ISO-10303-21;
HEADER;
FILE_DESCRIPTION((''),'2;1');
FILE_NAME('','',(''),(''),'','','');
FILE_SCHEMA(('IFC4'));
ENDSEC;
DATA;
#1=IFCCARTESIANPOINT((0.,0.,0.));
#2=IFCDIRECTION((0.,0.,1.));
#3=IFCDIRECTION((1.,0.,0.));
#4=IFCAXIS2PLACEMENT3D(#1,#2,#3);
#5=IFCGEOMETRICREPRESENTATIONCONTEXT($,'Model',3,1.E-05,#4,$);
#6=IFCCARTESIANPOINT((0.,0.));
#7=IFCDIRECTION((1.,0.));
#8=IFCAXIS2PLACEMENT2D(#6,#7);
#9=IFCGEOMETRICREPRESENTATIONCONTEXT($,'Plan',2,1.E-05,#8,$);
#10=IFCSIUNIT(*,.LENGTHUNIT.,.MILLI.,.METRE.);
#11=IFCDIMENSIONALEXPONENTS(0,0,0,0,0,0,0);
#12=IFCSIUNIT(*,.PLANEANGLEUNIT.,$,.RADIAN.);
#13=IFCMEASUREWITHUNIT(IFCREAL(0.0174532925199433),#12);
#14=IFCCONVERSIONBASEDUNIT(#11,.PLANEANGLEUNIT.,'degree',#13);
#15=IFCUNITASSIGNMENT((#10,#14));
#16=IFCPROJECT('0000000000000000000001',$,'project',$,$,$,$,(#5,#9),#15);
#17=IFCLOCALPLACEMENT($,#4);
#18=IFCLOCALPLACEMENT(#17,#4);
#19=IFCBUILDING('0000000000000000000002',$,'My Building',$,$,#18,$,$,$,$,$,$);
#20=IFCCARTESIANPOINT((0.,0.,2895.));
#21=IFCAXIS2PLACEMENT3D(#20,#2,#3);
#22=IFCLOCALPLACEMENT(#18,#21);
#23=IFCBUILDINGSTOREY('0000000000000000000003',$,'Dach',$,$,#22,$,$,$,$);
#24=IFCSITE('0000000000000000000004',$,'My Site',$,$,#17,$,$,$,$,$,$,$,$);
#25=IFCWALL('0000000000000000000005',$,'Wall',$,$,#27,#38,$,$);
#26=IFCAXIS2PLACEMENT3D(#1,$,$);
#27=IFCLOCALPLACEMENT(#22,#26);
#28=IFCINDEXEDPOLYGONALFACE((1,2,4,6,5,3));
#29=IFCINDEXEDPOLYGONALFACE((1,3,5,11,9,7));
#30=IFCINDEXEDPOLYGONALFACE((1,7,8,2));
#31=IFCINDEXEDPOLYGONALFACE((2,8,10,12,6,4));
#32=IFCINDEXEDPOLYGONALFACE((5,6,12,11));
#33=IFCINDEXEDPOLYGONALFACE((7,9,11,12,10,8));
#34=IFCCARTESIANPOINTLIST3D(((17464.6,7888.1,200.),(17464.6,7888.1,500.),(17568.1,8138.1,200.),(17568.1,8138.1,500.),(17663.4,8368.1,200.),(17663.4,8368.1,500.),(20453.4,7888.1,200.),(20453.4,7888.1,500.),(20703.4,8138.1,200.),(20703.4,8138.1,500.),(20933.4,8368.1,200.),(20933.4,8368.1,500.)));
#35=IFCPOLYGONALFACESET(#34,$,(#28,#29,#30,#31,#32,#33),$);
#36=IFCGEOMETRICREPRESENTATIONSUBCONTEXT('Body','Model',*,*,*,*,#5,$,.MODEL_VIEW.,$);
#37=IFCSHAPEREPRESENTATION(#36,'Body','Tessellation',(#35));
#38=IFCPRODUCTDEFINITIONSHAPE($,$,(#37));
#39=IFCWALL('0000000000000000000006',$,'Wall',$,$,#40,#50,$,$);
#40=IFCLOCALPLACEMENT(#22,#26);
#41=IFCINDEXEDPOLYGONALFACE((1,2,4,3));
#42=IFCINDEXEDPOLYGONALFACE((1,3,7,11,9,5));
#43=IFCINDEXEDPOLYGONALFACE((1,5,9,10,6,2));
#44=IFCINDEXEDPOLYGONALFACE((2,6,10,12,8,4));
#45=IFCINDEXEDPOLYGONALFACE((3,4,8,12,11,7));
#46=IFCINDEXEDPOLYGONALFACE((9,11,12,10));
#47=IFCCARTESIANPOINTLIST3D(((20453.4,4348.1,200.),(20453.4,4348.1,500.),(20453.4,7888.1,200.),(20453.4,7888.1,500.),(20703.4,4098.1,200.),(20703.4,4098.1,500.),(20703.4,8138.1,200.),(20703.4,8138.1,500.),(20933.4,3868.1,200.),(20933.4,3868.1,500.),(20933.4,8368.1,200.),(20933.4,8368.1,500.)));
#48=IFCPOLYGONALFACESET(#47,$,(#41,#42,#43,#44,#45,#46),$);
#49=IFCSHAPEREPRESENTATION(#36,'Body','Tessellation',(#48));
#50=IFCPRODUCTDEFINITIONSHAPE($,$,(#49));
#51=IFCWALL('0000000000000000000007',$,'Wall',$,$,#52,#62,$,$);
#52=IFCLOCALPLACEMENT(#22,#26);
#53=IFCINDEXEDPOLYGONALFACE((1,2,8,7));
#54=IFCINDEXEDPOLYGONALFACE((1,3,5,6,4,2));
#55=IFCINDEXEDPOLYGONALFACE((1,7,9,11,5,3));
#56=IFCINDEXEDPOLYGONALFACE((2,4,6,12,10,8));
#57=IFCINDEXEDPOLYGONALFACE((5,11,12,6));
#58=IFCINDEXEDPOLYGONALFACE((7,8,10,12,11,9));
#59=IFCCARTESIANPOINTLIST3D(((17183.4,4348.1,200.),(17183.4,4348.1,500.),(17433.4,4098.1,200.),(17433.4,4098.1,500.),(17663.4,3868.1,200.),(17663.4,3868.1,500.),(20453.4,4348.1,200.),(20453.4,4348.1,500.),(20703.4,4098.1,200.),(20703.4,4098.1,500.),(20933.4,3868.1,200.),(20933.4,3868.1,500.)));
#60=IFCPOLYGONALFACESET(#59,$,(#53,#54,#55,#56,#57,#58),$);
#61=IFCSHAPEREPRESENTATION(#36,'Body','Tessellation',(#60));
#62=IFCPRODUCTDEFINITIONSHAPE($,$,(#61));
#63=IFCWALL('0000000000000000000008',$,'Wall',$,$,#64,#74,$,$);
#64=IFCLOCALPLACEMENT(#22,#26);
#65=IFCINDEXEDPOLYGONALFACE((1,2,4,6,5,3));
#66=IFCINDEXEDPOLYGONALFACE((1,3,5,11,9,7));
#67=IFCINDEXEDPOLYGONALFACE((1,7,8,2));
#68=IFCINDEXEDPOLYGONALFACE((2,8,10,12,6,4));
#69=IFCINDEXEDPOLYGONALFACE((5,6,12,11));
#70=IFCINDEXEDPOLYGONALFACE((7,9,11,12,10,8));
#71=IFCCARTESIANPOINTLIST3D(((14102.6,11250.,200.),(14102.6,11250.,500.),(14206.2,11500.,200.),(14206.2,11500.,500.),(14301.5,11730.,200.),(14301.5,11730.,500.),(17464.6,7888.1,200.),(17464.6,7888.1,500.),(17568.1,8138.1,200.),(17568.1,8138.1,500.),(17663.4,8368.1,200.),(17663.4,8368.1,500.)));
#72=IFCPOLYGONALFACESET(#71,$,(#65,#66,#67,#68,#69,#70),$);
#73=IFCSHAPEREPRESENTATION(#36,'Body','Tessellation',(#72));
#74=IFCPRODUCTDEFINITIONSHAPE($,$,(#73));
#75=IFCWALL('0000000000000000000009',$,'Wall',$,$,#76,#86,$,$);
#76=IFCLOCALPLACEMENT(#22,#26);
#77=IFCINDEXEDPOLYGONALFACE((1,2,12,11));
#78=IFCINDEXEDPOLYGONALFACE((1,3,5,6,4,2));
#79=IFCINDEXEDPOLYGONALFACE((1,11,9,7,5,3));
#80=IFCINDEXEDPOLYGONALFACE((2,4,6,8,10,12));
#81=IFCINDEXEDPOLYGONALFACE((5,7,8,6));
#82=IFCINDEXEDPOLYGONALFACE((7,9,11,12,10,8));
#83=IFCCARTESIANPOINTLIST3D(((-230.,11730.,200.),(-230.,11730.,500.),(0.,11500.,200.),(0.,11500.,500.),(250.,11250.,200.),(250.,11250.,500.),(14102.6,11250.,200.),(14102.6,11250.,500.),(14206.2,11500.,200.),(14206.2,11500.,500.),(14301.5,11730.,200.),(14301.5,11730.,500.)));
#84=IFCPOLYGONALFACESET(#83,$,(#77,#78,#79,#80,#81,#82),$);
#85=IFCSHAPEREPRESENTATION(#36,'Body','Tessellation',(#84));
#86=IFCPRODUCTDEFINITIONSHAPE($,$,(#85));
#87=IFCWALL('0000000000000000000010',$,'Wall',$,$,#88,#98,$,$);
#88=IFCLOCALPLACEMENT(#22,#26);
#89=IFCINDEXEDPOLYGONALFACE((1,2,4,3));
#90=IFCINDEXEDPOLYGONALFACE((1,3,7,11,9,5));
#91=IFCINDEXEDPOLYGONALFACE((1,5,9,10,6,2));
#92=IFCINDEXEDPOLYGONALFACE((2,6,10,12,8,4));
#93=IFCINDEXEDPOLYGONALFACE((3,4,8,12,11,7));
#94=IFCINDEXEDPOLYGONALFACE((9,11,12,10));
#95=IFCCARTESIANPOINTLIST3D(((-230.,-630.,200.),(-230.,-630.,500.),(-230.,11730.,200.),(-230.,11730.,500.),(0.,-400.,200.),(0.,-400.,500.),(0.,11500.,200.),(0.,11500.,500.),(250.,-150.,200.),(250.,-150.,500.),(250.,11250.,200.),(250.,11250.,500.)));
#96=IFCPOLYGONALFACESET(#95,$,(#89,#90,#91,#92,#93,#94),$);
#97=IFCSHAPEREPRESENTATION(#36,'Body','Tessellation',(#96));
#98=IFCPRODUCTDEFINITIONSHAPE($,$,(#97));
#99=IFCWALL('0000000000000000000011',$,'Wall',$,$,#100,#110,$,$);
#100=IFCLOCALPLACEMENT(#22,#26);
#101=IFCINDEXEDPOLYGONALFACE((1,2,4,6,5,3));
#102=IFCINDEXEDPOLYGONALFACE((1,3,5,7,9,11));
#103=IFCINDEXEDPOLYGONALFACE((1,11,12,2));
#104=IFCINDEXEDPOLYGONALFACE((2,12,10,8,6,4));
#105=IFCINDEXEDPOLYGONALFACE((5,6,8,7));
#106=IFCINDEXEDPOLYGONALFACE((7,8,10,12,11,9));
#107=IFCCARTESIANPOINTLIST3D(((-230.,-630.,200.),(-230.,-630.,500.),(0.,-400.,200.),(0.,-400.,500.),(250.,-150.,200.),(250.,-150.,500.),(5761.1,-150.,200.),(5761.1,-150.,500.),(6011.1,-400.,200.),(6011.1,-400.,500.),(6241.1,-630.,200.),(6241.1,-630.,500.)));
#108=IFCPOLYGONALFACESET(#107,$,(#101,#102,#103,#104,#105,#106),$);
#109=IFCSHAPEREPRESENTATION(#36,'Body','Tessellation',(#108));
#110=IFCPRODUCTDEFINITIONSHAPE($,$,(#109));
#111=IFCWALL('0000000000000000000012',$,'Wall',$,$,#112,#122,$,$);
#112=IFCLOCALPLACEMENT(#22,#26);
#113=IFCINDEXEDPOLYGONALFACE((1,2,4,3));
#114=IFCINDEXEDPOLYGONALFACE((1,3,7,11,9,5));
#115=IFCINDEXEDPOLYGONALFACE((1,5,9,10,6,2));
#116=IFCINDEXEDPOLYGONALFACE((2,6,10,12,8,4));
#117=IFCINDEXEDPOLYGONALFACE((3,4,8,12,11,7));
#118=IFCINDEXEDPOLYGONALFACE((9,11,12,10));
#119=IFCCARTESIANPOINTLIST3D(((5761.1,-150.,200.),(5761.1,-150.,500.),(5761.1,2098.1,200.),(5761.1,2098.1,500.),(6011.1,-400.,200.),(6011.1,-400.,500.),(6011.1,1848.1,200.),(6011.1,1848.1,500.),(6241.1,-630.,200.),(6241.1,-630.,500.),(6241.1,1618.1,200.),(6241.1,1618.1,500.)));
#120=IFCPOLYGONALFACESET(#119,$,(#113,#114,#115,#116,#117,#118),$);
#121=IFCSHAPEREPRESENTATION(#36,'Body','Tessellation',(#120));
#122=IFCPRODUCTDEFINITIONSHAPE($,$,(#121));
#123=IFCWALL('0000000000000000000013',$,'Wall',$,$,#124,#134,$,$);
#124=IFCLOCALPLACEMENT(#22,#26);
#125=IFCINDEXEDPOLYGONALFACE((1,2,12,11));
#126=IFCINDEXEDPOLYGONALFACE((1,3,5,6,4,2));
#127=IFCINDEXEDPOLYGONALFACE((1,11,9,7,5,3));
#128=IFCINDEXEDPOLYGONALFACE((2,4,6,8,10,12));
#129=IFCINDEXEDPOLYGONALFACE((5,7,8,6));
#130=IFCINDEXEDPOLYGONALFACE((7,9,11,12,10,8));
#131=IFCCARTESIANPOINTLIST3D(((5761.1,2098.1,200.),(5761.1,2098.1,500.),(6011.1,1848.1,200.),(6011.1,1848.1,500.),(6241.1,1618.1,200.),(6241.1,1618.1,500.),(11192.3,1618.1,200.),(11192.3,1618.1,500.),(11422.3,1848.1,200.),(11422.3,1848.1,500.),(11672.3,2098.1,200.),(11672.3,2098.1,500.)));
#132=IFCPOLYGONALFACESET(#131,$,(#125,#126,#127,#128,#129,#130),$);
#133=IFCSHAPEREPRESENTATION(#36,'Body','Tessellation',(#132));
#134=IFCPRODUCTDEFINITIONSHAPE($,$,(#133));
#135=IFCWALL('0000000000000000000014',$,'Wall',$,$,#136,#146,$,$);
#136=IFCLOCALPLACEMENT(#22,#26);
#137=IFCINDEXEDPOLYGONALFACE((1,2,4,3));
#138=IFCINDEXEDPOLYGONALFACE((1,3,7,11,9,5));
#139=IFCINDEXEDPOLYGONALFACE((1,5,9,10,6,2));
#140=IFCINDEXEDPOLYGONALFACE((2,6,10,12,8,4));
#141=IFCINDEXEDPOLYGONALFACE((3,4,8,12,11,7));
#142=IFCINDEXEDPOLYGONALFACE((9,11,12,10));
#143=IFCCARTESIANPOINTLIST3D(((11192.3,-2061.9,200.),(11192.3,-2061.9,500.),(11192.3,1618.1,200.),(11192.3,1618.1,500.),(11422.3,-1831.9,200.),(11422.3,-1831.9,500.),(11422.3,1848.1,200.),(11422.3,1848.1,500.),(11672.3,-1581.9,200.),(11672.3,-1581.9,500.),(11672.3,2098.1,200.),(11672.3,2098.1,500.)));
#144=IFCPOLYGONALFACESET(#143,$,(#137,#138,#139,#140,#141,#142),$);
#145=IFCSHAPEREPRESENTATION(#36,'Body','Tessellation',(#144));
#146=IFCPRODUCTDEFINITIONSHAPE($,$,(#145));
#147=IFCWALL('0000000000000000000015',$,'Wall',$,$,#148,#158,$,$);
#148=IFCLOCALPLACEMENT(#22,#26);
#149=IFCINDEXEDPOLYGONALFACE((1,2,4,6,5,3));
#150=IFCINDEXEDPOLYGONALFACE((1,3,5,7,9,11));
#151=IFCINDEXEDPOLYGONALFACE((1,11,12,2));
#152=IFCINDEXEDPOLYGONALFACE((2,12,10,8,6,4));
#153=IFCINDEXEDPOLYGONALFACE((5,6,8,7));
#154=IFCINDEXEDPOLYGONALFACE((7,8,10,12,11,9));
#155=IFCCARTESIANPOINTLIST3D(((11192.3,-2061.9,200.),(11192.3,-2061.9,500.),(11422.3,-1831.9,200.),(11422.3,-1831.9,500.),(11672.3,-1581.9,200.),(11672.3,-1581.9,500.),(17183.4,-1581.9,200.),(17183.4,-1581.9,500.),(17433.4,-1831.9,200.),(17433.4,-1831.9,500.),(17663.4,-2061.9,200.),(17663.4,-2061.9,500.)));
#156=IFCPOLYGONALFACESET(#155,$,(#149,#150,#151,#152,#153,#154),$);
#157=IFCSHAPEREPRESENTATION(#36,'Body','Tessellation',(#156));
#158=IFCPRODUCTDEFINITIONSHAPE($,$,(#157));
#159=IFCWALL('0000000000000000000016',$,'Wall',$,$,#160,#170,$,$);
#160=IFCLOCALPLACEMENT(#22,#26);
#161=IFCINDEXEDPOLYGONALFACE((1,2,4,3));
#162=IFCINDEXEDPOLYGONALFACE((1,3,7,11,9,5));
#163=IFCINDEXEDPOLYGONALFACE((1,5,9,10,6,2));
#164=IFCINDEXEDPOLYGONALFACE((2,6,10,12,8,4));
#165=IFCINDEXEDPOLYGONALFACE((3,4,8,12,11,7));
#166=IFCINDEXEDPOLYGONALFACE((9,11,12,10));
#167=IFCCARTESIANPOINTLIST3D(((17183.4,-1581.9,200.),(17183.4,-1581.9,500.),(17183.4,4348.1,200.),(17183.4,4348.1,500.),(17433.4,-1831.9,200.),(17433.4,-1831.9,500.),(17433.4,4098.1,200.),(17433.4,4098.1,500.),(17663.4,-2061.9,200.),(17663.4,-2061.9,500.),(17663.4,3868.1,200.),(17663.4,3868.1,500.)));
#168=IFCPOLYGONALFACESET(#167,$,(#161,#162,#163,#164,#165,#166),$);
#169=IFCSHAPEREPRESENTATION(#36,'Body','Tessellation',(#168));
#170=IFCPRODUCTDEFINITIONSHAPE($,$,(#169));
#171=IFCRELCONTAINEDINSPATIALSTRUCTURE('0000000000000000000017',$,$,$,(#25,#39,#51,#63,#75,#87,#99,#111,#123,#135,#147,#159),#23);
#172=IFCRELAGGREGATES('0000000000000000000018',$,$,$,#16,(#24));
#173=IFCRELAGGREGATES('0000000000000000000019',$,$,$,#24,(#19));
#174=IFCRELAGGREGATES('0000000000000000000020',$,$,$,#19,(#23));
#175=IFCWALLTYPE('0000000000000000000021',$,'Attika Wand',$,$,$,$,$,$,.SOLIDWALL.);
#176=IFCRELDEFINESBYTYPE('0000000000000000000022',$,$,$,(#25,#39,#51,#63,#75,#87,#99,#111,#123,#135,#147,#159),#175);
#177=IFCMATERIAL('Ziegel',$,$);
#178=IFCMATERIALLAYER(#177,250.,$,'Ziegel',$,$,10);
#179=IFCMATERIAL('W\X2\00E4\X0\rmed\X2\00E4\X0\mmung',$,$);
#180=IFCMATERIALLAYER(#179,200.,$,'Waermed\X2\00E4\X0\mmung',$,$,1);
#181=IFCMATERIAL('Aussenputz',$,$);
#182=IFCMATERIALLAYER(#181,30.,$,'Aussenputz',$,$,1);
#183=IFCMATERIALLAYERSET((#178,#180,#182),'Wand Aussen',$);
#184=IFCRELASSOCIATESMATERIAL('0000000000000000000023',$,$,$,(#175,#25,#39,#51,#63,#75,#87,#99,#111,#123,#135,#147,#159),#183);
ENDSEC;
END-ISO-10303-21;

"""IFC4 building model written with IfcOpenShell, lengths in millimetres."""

from ifc_helpers import new_model, entity, si_unit, converted_unit, frame, origin_with_axes, origin_2d_with_axis, place, context, subcontext, project, spatial, line, indexed_curve, outline, extrude, material, layer, layer_set, layer_usage, type_object, element, save


model = new_model("IFC4")

# Units and contexts
model_context = context("Model", 3, precision=1e-05, world=origin_with_axes())
plan_context = context("Plan", 2, precision=1e-05, world=origin_2d_with_axis())
body_context = subcontext(model_context, "Body", "Model", "MODEL_VIEW")
ifc_project = project(units=[si_unit("LENGTHUNIT", "METRE", prefix="MILLI"), converted_unit("PLANEANGLEUNIT", "degree", entity("IfcReal", 0.0174532925199433), si_unit("PLANEANGLEUNIT", "RADIAN"), dimensions=[0, 0, 0, 0, 0, 0, 0])], contexts=[model_context, plan_context])

# Site, building, storey
site_placement = place(None, origin_with_axes())
site = spatial("IfcSite", under=ifc_project, at=site_placement, Name="My Site")
building_placement = place(site_placement, origin_with_axes())
building = spatial("IfcBuilding", under=site, at=building_placement, Name="My Building")
storey_placement = place(building_placement, frame((0.0, 0.0, 2895.0), z_axis=(0.0, 0.0, 1.0), x_axis=(1.0, 0.0, 0.0)))
storey = spatial("IfcBuildingStorey", under=building, at=storey_placement, Name="Dach")

# Walls
ifc_material_1 = material(Name="Ziegel")
ifc_layer_1 = layer(ifc_material_1, 250.0, Name="Ziegel", Priority=10)
ifc_material_2 = material(Name="Wärmedämmung")
ifc_layer_2 = layer(ifc_material_2, 200.0, Name="Waermedämmung", Priority=1)
ifc_material_3 = material(Name="Aussenputz")
ifc_layer_3 = layer(ifc_material_3, 30.0, Name="Aussenputz", Priority=1)
ifc_layer_set_1 = layer_set([ifc_layer_1, ifc_layer_2, ifc_layer_3], Name="Wand Aussen")
ifc_layer_usage_1 = layer_usage(ifc_layer_set_1, "AXIS2", "NEGATIVE", 0.0)
wall_type = type_object("IfcWallType", Name="Attika Wand", PredefinedType="SOLIDWALL", material=ifc_layer_set_1)
wall_1_placement = place(storey_placement, frame((20453.4, 7888.1, 200.0), z_axis=(0.0, 0.0, 1.0), x_axis=(-1.0, 0.0, 0.0)))
element("IfcWall", 1, at=wall_1_placement, inside=storey, type_object=wall_type, material=ifc_layer_usage_1, Name="Wall", context=body_context, shape_type="SweptSolid", body=[
    extrude(outline(indexed_curve([(-480.0, -480.0), (-250.0, -250.0), (0.0, 0.0), (2988.8, 0.0), (2885.3, -250.0), (2790.0, -480.0)], segments=[line(1, 2, 3, 4, 5, 6, 1)])), origin_with_axes(), (0.0, 0.0, 1.0), 300.0),
])
ifc_layer_usage_2 = layer_usage(ifc_layer_set_1, "AXIS2", "POSITIVE", 0.0)
wall_2_placement = place(storey_placement, frame((20453.4, 7888.1, 200.0), z_axis=(0.0, 0.0, 1.0), x_axis=(0.000001, -1.0, 0.0)))
element("IfcWall", 2, at=wall_2_placement, inside=storey, type_object=wall_type, material=ifc_layer_usage_2, Name="Wall", context=body_context, shape_type="SweptSolid", body=[
    extrude(outline(indexed_curve([(0.0, 0.0), (-250.0, 250.0), (-480.0, 480.0), (4020.0, 480.0), (3790.0, 250.0), (3540.0, 0.0)], segments=[line(1, 2, 3, 4, 5, 6, 1)])), origin_with_axes(), (0.0, 0.0, 1.0), 300.0),
])
ifc_layer_usage_3 = layer_usage(ifc_layer_set_1, "AXIS2", "NEGATIVE", 0.0)
wall_3_placement = place(storey_placement, frame((17183.4, 4348.1, 200.0), z_axis=(0.0, 0.0, 1.0), x_axis=(1.0, 0.0, 0.0)))
element("IfcWall", 3, at=wall_3_placement, inside=storey, type_object=wall_type, material=ifc_layer_usage_3, Name="Wall", context=body_context, shape_type="SweptSolid", body=[
    extrude(outline(indexed_curve([(480.0, -480.0), (250.0, -250.0), (0.0, 0.0), (3270.0, 0.0), (3520.0, -250.0), (3750.0, -480.0)], segments=[line(1, 2, 3, 4, 5, 6, 1)])), origin_with_axes(), (0.0, 0.0, 1.0), 300.0),
])
ifc_layer_usage_4 = layer_usage(ifc_layer_set_1, "AXIS2", "NEGATIVE", 0.0)
wall_4_placement = place(storey_placement, frame((17464.6, 7888.1, 200.0), z_axis=(0.0, 0.0, 1.0), x_axis=(-0.707107, 0.707107, 0.0)))
element("IfcWall", 4, at=wall_4_placement, inside=storey, type_object=wall_type, material=ifc_layer_usage_4, Name="Wall", context=body_context, shape_type="SweptSolid", body=[
    extrude(outline(indexed_curve([(198.8, -480.0), (103.6, -250.0), (0.0, 0.0), (4754.5, 0.0), (4858.1, -250.0), (4953.3, -480.0)], segments=[line(1, 2, 3, 4, 5, 6, 1)])), origin_with_axes(), (0.0, 0.0, 1.0), 300.0),
])
ifc_layer_usage_5 = layer_usage(ifc_layer_set_1, "AXIS2", "NEGATIVE", 0.0)
wall_5_placement = place(storey_placement, frame((14102.6, 11250.0, 200.0), z_axis=(0.0, 0.0, 1.0), x_axis=(-1.0, 0.0, 0.0)))
element("IfcWall", 5, at=wall_5_placement, inside=storey, type_object=wall_type, material=ifc_layer_usage_5, Name="Wall", context=body_context, shape_type="SweptSolid", body=[
    extrude(outline(indexed_curve([(-198.8, -480.0), (-103.6, -250.0), (0.0, 0.0), (13852.6, 0.0), (14102.6, -250.0), (14332.6, -480.0)], segments=[line(1, 2, 3, 4, 5, 6, 1)])), origin_with_axes(), (0.0, 0.0, 1.0), 300.0),
])
ifc_layer_usage_6 = layer_usage(ifc_layer_set_1, "AXIS2", "NEGATIVE", 0.0)
wall_6_placement = place(storey_placement, frame((250.0, 11250.0, 200.0), z_axis=(0.0, 0.0, 1.0), x_axis=(0.0, -1.0, 0.0)))
element("IfcWall", 6, at=wall_6_placement, inside=storey, type_object=wall_type, material=ifc_layer_usage_6, Name="Wall", context=body_context, shape_type="SweptSolid", body=[
    extrude(outline(indexed_curve([(-480.0, -480.0), (-250.0, -250.0), (0.0, 0.0), (11400.0, 0.0), (11650.0, -250.0), (11880.0, -480.0)], segments=[line(1, 2, 3, 4, 5, 6, 1)])), origin_with_axes(), (0.0, 0.0, 1.0), 300.0),
])
ifc_layer_usage_7 = layer_usage(ifc_layer_set_1, "AXIS2", "NEGATIVE", 0.0)
wall_7_placement = place(storey_placement, frame((250.0, -150.0, 200.0), z_axis=(0.0, 0.0, 1.0), x_axis=(1.0, 0.0, 0.0)))
element("IfcWall", 7, at=wall_7_placement, inside=storey, type_object=wall_type, material=ifc_layer_usage_7, Name="Wall", context=body_context, shape_type="SweptSolid", body=[
    extrude(outline(indexed_curve([(-480.0, -480.0), (-250.0, -250.0), (0.0, 0.0), (5511.1, 0.0), (5761.1, -250.0), (5991.1, -480.0)], segments=[line(1, 2, 3, 4, 5, 6, 1)])), origin_with_axes(), (0.0, 0.0, 1.0), 300.0),
])
ifc_layer_usage_8 = layer_usage(ifc_layer_set_1, "AXIS2", "NEGATIVE", 0.0)
wall_8_placement = place(storey_placement, frame((5761.1, -150.0, 200.0), z_axis=(0.0, 0.0, 1.0), x_axis=(0.0, 1.0, 0.0)))
element("IfcWall", 8, at=wall_8_placement, inside=storey, type_object=wall_type, material=ifc_layer_usage_8, Name="Wall", context=body_context, shape_type="SweptSolid", body=[
    extrude(outline(indexed_curve([(-480.0, -480.0), (-250.0, -250.0), (0.0, 0.0), (2248.1, 0.0), (1998.1, -250.0), (1768.1, -480.0)], segments=[line(1, 2, 3, 4, 5, 6, 1)])), origin_with_axes(), (0.0, 0.0, 1.0), 300.0),
])
ifc_layer_usage_9 = layer_usage(ifc_layer_set_1, "AXIS2", "POSITIVE", 0.0)
wall_9_placement = place(storey_placement, frame((11672.3, 2098.1, 200.0), z_axis=(0.0, 0.0, 1.0), x_axis=(-1.0, 0.0, 0.0)))
element("IfcWall", 9, at=wall_9_placement, inside=storey, type_object=wall_type, material=ifc_layer_usage_9, Name="Wall", context=body_context, shape_type="SweptSolid", body=[
    extrude(outline(indexed_curve([(0.0, 0.0), (250.0, 250.0), (480.0, 480.0), (5431.1, 480.0), (5661.1, 250.0), (5911.1, 0.0)], segments=[line(1, 2, 3, 4, 5, 6, 1)])), origin_with_axes(), (0.0, 0.0, 1.0), 300.0),
])
ifc_layer_usage_10 = layer_usage(ifc_layer_set_1, "AXIS2", "POSITIVE", 0.0)
wall_10_placement = place(storey_placement, frame((11672.3, -1581.9, 200.0), z_axis=(0.0, 0.0, 1.0), x_axis=(0.0, 1.0, 0.0)))
element("IfcWall", 10, at=wall_10_placement, inside=storey, type_object=wall_type, material=ifc_layer_usage_10, Name="Wall", context=body_context, shape_type="SweptSolid", body=[
    extrude(outline(indexed_curve([(0.0, 0.0), (-250.0, 250.0), (-480.0, 480.0), (3200.0, 480.0), (3430.0, 250.0), (3680.0, 0.0)], segments=[line(1, 2, 3, 4, 5, 6, 1)])), origin_with_axes(), (0.0, 0.0, 1.0), 300.0),
])
ifc_layer_usage_11 = layer_usage(ifc_layer_set_1, "AXIS2", "POSITIVE", 0.0)
wall_11_placement = place(storey_placement, frame((17183.4, -1581.9, 200.0), z_axis=(0.0, 0.0, 1.0), x_axis=(-1.0, 0.0, 0.0)))
element("IfcWall", 11, at=wall_11_placement, inside=storey, type_object=wall_type, material=ifc_layer_usage_11, Name="Wall", context=body_context, shape_type="SweptSolid", body=[
    extrude(outline(indexed_curve([(0.0, 0.0), (-250.0, 250.0), (-480.0, 480.0), (5991.2, 480.0), (5761.2, 250.0), (5511.2, 0.0)], segments=[line(1, 2, 3, 4, 5, 6, 1)])), origin_with_axes(), (0.0, 0.0, 1.0), 300.0),
])
ifc_layer_usage_12 = layer_usage(ifc_layer_set_1, "AXIS2", "NEGATIVE", 0.0)
wall_12_placement = place(storey_placement, frame((17183.4, -1581.9, 200.0), z_axis=(0.0, 0.0, 1.0), x_axis=(0.0, 1.0, 0.0)))
element("IfcWall", 12, at=wall_12_placement, inside=storey, type_object=wall_type, material=ifc_layer_usage_12, Name="Wall", context=body_context, shape_type="SweptSolid", body=[
    extrude(outline(indexed_curve([(-480.0, -480.0), (-250.0, -250.0), (0.0, 0.0), (5930.0, 0.0), (5680.0, -250.0), (5450.0, -480.0)], segments=[line(1, 2, 3, 4, 5, 6, 1)])), origin_with_axes(), (0.0, 0.0, 1.0), 300.0),
])

save(model, "model.ifc")
